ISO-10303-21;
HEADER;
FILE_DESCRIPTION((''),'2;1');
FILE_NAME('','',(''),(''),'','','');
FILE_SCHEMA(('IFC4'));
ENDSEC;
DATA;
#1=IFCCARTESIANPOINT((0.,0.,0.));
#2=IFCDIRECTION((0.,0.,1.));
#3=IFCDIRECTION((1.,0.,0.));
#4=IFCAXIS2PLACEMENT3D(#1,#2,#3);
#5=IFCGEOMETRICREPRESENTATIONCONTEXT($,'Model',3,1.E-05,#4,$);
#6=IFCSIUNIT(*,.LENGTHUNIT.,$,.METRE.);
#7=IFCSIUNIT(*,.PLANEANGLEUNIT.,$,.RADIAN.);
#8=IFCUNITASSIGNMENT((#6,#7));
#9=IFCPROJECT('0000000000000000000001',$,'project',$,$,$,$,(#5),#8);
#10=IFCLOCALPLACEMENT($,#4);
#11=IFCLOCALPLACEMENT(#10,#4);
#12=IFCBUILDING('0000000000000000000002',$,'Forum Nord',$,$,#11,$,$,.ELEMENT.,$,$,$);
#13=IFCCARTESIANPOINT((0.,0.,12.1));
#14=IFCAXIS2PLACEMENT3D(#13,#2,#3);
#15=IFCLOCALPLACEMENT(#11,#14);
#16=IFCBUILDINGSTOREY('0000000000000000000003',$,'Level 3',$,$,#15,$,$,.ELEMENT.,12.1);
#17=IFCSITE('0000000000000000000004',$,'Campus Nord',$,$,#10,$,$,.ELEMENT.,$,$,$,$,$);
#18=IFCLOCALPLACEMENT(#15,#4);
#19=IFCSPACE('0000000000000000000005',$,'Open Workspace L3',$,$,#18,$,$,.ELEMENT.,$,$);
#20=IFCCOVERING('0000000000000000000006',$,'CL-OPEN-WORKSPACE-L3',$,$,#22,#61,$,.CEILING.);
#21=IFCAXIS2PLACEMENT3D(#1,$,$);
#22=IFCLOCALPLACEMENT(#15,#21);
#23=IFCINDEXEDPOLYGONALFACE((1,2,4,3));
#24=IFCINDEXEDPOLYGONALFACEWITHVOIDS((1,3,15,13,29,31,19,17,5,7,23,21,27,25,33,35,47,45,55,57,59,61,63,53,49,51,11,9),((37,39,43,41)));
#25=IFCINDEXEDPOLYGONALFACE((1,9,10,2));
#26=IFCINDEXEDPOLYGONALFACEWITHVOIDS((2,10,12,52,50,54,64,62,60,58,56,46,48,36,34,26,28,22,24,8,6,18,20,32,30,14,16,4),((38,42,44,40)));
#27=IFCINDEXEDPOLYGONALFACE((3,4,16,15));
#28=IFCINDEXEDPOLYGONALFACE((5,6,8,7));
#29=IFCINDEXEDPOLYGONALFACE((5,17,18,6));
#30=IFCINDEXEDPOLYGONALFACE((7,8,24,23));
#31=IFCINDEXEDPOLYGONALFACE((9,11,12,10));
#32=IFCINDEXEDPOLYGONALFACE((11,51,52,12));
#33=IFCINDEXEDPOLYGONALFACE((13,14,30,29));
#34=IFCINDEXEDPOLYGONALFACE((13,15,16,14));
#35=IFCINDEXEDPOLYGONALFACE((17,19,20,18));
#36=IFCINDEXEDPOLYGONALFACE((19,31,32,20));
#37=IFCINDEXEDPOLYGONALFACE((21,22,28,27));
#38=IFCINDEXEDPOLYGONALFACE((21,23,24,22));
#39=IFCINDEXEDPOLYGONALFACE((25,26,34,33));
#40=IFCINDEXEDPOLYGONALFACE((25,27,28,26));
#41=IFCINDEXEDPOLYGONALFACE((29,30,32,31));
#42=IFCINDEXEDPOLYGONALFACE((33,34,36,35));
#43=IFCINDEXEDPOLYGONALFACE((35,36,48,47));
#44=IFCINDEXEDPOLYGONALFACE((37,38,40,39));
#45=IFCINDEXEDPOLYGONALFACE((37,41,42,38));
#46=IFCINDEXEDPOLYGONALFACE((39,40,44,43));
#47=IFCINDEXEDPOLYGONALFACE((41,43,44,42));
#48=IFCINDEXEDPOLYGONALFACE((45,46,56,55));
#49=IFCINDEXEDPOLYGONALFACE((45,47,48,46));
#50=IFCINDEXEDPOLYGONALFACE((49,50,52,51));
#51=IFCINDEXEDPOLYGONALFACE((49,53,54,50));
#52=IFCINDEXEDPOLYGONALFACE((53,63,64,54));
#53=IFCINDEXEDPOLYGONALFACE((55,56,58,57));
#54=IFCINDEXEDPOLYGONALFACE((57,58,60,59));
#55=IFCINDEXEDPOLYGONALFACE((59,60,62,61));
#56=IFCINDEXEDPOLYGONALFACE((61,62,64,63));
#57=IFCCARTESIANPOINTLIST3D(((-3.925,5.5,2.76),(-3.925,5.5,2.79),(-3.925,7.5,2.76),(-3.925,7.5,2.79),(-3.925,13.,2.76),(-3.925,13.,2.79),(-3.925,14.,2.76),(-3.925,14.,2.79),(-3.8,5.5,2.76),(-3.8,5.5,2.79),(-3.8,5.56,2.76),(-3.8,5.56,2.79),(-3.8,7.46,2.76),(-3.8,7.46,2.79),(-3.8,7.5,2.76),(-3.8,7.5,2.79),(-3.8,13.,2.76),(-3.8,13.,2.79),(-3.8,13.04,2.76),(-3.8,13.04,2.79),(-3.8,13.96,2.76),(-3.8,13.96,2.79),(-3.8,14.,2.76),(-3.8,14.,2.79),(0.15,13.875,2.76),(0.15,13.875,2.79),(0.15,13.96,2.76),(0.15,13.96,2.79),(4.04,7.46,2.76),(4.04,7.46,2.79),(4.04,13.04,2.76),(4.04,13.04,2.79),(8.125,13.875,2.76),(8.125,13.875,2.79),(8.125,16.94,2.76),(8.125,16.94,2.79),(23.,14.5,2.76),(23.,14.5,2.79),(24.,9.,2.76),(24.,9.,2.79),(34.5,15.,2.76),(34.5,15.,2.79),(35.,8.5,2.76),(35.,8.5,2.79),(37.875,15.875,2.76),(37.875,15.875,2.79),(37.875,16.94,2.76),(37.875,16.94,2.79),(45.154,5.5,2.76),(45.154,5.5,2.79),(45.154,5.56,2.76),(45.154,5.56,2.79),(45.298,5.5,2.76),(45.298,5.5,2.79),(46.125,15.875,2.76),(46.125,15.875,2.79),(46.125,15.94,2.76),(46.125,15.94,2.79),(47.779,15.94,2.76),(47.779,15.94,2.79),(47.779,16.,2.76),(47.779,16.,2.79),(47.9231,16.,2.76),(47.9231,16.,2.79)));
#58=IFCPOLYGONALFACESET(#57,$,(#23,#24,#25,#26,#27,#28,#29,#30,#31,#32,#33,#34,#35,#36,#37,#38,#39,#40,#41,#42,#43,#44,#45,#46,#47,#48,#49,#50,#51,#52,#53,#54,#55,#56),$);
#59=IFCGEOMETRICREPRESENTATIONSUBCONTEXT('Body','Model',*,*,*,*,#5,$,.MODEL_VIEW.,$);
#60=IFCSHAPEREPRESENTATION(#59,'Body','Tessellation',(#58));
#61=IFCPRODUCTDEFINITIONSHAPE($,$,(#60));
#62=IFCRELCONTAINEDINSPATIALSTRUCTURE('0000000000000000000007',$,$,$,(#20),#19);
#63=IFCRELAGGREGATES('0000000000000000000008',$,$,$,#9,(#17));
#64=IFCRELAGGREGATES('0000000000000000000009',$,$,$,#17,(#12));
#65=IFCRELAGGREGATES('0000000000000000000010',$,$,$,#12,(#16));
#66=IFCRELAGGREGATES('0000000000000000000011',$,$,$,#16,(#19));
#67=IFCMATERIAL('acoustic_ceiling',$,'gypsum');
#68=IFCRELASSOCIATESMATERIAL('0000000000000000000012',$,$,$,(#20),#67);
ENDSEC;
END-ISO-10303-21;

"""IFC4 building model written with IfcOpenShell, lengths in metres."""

from ifc_helpers import new_model, si_unit, frame, origin_with_axes, place, context, subcontext, project, spatial, polyline, outline, extrude, material, element, save


model = new_model("IFC4")

# Units and contexts
model_context = context("Model", 3, precision=1e-05, world=origin_with_axes())
body_context = subcontext(model_context, "Body", "Model", "MODEL_VIEW")
ifc_project = project(units=[si_unit("LENGTHUNIT", "METRE"), si_unit("PLANEANGLEUNIT", "RADIAN")], contexts=[model_context])

# Site, building, storey
site_placement = place(None, origin_with_axes())
site = spatial("IfcSite", under=ifc_project, at=site_placement, Name="Campus Nord", CompositionType="ELEMENT")
building_placement = place(site_placement, origin_with_axes())
building = spatial("IfcBuilding", under=site, at=building_placement, Name="Forum Nord", CompositionType="ELEMENT")
storey_placement = place(building_placement, frame((0.0, 0.0, 12.1), z_axis=(0.0, 0.0, 1.0), x_axis=(1.0, 0.0, 0.0)))
storey = spatial("IfcBuildingStorey", under=building, at=storey_placement, Name="Level 3", CompositionType="ELEMENT", Elevation=12.1)

# Shared definitions
ifc_material_1 = material(Name="acoustic_ceiling", Category="gypsum")

# Shared definitions
space_1_placement = place(storey_placement, origin_with_axes())
space_1 = spatial("IfcSpace", under=storey, at=space_1_placement, Name="Open Workspace L3", CompositionType="ELEMENT")

# Covering
covering_1_placement = place(storey_placement, frame((0.0, 0.0, 2.76), z_axis=(0.0, 0.0, 1.0), x_axis=(1.0, 0.0, 0.0)))
element("IfcCovering", 1, at=covering_1_placement, inside=space_1, material=ifc_material_1, Name="CL-OPEN-WORKSPACE-L3", PredefinedType="CEILING", context=body_context, shape_type="SweptSolid", body=[
    extrude(outline(polyline([(-3.925, 7.5), (-3.925, 5.5), (-3.8, 5.5), (-3.8, 5.56), (45.154, 5.56), (45.154, 5.5), (45.298, 5.5), (47.9231, 16.0), (47.779, 16.0), (47.779, 15.94), (46.125, 15.94), (46.125, 15.875), (37.875, 15.875), (37.875, 16.94), (8.125, 16.94), (8.125, 13.875), (0.15, 13.875), (0.15, 13.96), (-3.8, 13.96), (-3.8, 14.0), (-3.925, 14.0), (-3.925, 13.0), (-3.8, 13.0), (-3.8, 13.04), (4.04, 13.04), (4.04, 7.46), (-3.8, 7.46), (-3.8, 7.5), (-3.925, 7.5)]), holes=[polyline([(23.0, 14.5), (34.5, 15.0), (35.0, 8.5), (24.0, 9.0), (23.0, 14.5)])]), origin_with_axes(), (0.0, 0.0, 1.0), 0.03),
])

save(model, "model.ifc")
